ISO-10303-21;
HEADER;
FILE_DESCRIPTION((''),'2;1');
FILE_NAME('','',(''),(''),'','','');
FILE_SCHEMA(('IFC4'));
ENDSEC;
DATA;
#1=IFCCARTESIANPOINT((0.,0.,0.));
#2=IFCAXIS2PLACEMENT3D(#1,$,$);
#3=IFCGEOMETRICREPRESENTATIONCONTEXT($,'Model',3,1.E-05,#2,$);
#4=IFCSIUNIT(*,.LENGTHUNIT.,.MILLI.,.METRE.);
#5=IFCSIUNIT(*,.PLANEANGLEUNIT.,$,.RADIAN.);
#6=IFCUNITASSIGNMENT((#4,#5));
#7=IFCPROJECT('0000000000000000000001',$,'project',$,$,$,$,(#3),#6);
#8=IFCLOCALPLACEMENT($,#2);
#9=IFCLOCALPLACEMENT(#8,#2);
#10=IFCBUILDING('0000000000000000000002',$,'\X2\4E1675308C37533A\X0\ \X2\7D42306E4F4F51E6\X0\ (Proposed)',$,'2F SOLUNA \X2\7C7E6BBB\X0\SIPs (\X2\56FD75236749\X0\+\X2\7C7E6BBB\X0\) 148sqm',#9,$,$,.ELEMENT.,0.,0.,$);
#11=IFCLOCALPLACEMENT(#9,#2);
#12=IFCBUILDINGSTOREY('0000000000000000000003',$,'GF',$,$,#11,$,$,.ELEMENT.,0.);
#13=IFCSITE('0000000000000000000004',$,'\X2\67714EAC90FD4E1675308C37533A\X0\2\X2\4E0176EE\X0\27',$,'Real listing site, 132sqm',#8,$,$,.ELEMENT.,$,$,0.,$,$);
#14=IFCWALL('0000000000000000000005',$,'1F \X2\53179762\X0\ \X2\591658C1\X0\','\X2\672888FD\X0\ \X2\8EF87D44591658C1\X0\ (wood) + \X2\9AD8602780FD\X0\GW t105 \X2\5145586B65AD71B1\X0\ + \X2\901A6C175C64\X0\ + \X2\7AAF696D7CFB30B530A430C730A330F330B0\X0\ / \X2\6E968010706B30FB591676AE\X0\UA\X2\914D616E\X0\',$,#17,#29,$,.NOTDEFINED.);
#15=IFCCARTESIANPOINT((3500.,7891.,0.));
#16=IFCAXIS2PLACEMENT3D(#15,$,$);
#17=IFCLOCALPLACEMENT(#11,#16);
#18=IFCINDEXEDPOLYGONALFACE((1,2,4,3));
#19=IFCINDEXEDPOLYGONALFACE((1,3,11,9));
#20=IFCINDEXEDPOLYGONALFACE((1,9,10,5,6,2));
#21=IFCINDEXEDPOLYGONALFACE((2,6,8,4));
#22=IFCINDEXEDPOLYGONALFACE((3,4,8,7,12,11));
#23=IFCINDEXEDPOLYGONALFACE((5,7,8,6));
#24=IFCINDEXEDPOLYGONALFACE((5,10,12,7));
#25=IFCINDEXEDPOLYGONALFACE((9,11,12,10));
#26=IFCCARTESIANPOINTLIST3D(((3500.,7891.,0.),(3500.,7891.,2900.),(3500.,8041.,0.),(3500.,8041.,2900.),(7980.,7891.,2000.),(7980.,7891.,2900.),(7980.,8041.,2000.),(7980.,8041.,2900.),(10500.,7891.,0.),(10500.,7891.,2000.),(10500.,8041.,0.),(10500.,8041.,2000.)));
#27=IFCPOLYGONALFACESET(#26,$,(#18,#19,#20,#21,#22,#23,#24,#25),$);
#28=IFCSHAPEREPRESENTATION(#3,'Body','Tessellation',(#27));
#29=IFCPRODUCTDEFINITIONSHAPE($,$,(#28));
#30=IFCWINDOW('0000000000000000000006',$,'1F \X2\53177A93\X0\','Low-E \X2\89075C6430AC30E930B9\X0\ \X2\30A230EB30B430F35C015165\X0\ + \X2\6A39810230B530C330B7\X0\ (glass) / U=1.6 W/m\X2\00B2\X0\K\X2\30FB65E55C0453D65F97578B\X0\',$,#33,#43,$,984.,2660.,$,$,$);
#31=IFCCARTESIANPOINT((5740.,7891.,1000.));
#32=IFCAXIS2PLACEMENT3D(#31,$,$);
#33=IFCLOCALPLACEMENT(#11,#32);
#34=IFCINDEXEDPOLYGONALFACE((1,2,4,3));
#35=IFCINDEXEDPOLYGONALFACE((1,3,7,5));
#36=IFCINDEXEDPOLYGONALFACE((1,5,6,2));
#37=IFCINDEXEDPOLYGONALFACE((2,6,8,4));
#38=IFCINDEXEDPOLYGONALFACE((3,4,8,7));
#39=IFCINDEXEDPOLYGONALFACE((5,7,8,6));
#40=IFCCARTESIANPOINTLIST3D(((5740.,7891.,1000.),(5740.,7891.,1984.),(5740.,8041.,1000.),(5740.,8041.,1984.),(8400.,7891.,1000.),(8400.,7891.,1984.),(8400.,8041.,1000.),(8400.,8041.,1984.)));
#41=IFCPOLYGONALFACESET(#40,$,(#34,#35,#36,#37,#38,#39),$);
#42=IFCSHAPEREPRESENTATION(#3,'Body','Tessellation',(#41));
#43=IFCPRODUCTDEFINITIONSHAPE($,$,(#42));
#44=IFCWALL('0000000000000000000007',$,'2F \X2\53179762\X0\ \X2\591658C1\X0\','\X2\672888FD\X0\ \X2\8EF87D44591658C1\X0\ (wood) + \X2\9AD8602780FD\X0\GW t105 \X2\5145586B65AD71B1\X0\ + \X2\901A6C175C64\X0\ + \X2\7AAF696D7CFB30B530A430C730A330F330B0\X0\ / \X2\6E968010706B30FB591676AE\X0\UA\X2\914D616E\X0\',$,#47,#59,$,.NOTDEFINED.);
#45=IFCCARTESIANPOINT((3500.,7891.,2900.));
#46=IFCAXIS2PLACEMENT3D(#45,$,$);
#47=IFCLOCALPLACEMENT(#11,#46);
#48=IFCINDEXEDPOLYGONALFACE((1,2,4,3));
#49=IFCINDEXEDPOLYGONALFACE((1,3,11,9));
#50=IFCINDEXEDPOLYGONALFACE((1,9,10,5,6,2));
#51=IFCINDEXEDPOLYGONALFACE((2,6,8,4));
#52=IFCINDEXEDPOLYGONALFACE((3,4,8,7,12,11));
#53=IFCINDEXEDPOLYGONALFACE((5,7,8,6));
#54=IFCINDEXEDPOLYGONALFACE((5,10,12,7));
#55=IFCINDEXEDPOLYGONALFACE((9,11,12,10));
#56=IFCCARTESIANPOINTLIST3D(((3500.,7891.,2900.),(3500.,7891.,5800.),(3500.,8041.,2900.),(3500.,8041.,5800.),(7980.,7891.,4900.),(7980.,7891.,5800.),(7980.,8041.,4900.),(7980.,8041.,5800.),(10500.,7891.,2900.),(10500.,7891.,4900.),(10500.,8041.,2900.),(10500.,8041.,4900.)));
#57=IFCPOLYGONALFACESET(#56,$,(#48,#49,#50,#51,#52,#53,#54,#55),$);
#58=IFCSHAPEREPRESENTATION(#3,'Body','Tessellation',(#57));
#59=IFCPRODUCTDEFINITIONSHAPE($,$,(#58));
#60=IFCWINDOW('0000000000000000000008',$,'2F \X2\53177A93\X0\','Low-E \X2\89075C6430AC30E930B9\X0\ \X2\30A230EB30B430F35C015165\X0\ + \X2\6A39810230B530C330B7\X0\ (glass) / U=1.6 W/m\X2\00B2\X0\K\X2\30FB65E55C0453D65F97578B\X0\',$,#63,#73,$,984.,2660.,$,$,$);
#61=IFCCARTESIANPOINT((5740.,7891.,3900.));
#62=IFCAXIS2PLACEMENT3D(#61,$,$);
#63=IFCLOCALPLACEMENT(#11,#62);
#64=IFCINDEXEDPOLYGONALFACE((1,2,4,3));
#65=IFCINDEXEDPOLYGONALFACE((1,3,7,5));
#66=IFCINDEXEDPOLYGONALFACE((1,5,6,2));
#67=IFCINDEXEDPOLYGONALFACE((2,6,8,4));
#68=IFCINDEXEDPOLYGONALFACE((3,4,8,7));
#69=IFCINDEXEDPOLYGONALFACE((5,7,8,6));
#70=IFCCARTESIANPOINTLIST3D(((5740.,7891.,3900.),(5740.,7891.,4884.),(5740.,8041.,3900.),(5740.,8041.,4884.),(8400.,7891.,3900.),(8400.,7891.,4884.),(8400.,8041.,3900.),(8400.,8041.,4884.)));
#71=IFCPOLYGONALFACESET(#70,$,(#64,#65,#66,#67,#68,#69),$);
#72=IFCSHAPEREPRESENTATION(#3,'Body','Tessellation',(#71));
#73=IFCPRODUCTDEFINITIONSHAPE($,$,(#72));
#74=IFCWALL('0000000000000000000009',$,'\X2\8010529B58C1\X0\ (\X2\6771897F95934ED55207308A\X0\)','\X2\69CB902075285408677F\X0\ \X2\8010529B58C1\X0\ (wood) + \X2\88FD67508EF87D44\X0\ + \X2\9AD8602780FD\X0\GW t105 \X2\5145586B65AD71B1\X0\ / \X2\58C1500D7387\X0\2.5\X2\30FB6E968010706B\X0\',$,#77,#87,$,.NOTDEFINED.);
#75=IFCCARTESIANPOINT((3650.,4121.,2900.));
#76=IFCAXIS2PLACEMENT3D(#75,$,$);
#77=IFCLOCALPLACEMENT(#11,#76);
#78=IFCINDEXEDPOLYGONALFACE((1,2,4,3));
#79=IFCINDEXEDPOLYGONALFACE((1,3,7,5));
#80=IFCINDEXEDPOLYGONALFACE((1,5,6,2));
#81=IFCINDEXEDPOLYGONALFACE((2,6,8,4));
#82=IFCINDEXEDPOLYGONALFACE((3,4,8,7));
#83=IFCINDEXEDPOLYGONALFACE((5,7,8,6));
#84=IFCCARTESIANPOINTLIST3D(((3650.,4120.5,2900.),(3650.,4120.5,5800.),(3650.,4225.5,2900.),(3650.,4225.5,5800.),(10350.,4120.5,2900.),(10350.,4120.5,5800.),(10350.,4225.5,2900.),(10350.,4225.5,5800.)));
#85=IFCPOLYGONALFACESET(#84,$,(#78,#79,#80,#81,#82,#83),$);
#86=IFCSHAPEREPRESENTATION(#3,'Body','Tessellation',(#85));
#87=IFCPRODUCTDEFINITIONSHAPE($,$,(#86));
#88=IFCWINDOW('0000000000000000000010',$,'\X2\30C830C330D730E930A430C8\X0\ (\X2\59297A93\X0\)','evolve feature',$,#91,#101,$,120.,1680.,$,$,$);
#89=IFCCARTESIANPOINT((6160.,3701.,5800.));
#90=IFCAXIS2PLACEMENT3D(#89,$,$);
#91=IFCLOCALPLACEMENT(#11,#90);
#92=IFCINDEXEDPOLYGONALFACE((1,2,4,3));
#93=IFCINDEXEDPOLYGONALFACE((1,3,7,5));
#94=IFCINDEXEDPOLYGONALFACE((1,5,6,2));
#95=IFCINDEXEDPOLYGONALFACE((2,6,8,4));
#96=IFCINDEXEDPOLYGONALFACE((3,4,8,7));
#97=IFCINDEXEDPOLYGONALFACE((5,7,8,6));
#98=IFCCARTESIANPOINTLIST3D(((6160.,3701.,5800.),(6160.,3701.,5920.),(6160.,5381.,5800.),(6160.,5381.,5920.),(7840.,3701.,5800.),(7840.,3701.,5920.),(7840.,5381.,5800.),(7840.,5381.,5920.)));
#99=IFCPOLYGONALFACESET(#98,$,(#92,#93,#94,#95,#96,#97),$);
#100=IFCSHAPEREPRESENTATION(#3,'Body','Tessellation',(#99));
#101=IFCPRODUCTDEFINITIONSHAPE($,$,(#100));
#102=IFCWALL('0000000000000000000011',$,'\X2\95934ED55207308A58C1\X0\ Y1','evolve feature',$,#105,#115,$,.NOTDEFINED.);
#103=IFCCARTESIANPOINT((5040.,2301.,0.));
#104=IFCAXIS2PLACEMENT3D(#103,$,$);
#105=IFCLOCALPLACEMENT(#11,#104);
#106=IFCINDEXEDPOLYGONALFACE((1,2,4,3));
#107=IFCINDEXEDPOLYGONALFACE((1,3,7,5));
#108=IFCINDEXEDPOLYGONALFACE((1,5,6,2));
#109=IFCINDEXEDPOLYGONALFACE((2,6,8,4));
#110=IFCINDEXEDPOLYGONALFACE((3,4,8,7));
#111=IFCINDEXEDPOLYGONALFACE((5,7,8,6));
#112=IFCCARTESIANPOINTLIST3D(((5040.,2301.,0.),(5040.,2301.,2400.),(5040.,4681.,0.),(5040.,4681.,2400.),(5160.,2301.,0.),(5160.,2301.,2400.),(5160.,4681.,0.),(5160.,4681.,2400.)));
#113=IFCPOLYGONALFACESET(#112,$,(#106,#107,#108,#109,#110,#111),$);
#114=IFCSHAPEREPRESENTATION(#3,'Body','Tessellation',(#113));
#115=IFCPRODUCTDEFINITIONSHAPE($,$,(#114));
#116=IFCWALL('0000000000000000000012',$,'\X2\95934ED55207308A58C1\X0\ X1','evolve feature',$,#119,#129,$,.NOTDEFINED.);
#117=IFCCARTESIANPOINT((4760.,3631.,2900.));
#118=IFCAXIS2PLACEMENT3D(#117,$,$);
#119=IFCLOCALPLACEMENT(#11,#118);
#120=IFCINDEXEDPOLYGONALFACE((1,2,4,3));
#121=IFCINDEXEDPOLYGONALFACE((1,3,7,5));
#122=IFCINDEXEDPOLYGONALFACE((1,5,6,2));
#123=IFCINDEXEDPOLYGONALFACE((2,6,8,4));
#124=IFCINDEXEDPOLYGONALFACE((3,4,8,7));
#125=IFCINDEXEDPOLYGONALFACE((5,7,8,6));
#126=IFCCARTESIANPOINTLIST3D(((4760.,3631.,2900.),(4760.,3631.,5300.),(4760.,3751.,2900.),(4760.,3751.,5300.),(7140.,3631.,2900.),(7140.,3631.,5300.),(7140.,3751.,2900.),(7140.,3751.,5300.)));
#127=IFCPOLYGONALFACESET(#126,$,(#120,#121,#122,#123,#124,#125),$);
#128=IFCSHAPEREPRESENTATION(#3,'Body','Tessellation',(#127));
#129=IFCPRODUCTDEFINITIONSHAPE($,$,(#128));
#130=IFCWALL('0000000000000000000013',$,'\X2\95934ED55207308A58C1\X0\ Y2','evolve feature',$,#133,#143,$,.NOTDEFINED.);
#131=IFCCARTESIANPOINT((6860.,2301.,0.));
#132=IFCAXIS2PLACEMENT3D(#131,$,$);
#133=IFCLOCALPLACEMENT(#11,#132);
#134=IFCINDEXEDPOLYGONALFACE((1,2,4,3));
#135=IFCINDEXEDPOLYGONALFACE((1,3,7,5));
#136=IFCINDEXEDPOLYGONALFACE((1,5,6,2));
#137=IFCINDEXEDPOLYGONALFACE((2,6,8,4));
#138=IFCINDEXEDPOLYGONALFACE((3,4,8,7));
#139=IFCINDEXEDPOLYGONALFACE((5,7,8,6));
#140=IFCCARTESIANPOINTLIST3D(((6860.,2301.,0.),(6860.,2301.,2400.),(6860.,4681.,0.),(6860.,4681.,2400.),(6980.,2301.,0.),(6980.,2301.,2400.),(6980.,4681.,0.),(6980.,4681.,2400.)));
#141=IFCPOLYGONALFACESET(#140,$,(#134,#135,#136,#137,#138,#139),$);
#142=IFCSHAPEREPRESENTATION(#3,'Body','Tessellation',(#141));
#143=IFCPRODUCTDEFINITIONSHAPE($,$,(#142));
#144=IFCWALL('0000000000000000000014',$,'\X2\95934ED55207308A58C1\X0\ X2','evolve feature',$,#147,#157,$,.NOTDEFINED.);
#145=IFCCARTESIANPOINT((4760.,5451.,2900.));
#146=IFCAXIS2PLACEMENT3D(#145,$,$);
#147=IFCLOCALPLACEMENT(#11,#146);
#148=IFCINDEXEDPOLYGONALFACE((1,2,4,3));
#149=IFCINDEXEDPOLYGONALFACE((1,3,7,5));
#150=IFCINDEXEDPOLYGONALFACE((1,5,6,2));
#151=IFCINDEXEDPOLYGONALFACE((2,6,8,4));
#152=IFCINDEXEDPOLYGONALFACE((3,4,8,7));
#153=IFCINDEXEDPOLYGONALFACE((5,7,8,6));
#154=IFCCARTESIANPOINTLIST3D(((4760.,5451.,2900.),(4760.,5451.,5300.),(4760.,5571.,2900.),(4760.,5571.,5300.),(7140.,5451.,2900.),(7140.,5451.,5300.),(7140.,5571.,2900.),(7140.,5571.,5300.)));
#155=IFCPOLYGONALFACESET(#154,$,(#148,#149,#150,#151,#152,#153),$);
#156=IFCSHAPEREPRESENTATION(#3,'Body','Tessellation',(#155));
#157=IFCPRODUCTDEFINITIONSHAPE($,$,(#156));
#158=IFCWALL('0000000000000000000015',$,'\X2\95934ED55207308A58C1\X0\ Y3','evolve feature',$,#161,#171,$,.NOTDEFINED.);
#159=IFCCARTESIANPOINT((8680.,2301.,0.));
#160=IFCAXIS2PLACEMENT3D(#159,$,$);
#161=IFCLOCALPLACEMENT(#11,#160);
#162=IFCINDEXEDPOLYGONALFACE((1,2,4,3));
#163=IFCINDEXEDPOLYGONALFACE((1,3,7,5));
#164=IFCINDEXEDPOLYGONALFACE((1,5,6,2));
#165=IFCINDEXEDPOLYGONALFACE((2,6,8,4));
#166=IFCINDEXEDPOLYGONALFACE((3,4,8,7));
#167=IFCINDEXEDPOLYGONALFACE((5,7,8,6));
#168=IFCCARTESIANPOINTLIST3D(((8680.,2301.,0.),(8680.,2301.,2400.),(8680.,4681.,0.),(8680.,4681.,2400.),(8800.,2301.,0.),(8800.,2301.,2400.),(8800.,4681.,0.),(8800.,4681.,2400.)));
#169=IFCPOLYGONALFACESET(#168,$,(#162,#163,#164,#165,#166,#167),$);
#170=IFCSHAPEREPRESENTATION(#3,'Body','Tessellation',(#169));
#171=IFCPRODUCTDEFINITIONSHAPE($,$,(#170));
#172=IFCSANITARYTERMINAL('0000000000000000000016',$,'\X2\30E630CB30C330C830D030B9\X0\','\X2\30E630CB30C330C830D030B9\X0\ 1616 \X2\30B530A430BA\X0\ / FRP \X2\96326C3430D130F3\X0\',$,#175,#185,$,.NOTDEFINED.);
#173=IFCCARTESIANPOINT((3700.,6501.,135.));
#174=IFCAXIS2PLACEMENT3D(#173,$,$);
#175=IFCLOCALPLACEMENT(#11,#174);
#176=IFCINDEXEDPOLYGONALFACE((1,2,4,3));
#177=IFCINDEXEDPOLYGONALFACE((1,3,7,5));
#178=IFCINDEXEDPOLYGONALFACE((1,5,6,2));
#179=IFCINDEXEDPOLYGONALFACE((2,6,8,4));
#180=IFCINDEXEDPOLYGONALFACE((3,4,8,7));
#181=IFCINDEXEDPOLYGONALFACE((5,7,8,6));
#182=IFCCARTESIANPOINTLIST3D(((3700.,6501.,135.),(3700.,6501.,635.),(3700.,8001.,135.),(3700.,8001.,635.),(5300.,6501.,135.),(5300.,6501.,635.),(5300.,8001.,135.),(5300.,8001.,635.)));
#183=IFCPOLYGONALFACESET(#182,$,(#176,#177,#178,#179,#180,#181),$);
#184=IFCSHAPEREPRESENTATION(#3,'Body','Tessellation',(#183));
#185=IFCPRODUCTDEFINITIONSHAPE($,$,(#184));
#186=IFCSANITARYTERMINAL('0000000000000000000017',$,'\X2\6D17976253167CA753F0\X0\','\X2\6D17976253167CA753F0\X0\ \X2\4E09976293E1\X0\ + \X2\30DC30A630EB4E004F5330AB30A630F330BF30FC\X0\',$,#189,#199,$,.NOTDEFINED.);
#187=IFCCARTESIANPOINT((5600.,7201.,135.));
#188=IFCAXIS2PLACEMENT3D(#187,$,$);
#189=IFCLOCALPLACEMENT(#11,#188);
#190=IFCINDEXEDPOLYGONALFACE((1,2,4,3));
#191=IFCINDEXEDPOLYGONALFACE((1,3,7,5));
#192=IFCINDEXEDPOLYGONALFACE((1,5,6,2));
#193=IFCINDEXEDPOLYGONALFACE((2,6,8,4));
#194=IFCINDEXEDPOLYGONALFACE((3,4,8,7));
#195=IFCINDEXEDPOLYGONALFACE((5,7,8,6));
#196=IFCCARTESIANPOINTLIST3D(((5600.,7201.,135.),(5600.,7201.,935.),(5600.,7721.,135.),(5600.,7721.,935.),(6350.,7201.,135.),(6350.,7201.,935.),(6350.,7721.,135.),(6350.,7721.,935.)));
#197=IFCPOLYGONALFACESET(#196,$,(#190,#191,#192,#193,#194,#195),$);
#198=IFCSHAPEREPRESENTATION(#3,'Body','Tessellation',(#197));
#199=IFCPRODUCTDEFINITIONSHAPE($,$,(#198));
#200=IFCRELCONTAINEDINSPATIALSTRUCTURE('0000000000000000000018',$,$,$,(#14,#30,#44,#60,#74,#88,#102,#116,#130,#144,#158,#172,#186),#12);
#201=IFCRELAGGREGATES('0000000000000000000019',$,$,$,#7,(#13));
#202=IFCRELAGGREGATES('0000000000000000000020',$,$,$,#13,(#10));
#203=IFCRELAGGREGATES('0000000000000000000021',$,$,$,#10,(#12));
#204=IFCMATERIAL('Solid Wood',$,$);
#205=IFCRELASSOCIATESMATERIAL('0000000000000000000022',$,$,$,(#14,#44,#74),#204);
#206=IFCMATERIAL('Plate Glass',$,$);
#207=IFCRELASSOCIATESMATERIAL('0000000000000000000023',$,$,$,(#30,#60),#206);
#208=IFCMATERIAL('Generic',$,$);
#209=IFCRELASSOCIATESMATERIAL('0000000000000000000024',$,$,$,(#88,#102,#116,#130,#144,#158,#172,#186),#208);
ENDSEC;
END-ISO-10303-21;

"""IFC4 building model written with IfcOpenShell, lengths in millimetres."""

from ifc_helpers import new_model, si_unit, frame, frame_2d, origin, place, context, project, spatial, rectangle, extrude, material, element, fill, save


model = new_model("IFC4")

# Units and contexts
model_context = context("Model", 3, precision=1e-05, world=origin())
ifc_project = project(units=[si_unit("LENGTHUNIT", "METRE", prefix="MILLI"), si_unit("PLANEANGLEUNIT", "RADIAN")], contexts=[model_context])

# Site, building, storey
site_placement = place(None, origin())
site = spatial("IfcSite", under=ifc_project, at=site_placement, Name="東京都世田谷区2丁目27", ObjectType="Real listing site, 132sqm", CompositionType="ELEMENT", RefElevation=0.0)
building_placement = place(site_placement, origin())
building = spatial("IfcBuilding", under=site, at=building_placement, Name="世田谷区 終の住処 (Proposed)", ObjectType="2F SOLUNA 籾殻SIPs (国産杉+籾殻) 148sqm", CompositionType="ELEMENT", ElevationOfRefHeight=0.0, ElevationOfTerrain=0.0)
storey_placement = place(building_placement, origin())
storey = spatial("IfcBuildingStorey", under=building, at=storey_placement, Name="GF", CompositionType="ELEMENT", Elevation=0.0)

# Wall, opening, window
ifc_material_1 = material(Name="Solid Wood")
wall_1_placement = place(storey_placement, frame((3500.0, 7891.0, 0.0)))
wall_1 = element("IfcWall", 1, at=wall_1_placement, inside=storey, material=ifc_material_1, Name="1F 北面 外壁", Description="木製 軸組外壁 (wood) + 高性能GW t105 充填断熱 + 通気層 + 窯業系サイディング / 準耐火・外皮UA配慮", PredefinedType="NOTDEFINED", context=model_context, shape_type="SweptSolid", body=[
    extrude(rectangle(XDim=7000.0, YDim=150.0, at=frame_2d((3500.0, 75.0))), frame((3500.0, 7891.0, 0.0)), (0.0, 0.0, 1.0), 2900.0),
])
opening_1_placement = place(storey_placement, frame((5740.0, 7891.0, 1000.0)))
opening_1 = element("IfcOpeningElement", 2, at=opening_1_placement, cuts=wall_1, PredefinedType="NOTDEFINED", context=model_context, shape_type="SweptSolid", body=[
    extrude(rectangle(XDim=2660.0, YDim=150.0, at=frame_2d((1330.0, 75.0))), frame((5740.0, 7891.0, 1000.0)), (0.0, 0.0, 1.0), 984.0),
])
ifc_material_2 = material(Name="Plate Glass")
window_1_placement = place(storey_placement, frame((5740.0, 7891.0, 1000.0)))
window_1 = element("IfcWindow", 3, at=window_1_placement, inside=storey, material=ifc_material_2, Name="1F 北窓", Description="Low-E 複層ガラス アルゴン封入 + 樹脂サッシ (glass) / U=1.6 W/m²K・日射取得型", OverallHeight=984.0, OverallWidth=2660.0, context=model_context, shape_type="SweptSolid", body=[
    extrude(rectangle(XDim=2660.0, YDim=150.0, at=frame_2d((1330.0, 75.0))), frame((5740.0, 7891.0, 1000.0)), (0.0, 0.0, 1.0), 984.0),
])
fill(opening_1, window_1)

# Wall, opening, window
wall_2_placement = place(storey_placement, frame((3500.0, 7891.0, 2900.0)))
wall_2 = element("IfcWall", 4, at=wall_2_placement, inside=storey, material=ifc_material_1, Name="2F 北面 外壁", Description="木製 軸組外壁 (wood) + 高性能GW t105 充填断熱 + 通気層 + 窯業系サイディング / 準耐火・外皮UA配慮", PredefinedType="NOTDEFINED", context=model_context, shape_type="SweptSolid", body=[
    extrude(rectangle(XDim=7000.0, YDim=150.0, at=frame_2d((3500.0, 75.0))), frame((3500.0, 7891.0, 2900.0)), (0.0, 0.0, 1.0), 2900.0),
])
opening_2_placement = place(storey_placement, frame((5740.0, 7891.0, 3900.0)))
opening_2 = element("IfcOpeningElement", 5, at=opening_2_placement, cuts=wall_2, PredefinedType="NOTDEFINED", context=model_context, shape_type="SweptSolid", body=[
    extrude(rectangle(XDim=2660.0, YDim=150.0, at=frame_2d((1330.0, 75.0))), frame((5740.0, 7891.0, 3900.0)), (0.0, 0.0, 1.0), 984.0),
])
window_2_placement = place(storey_placement, frame((5740.0, 7891.0, 3900.0)))
window_2 = element("IfcWindow", 6, at=window_2_placement, inside=storey, material=ifc_material_2, Name="2F 北窓", Description="Low-E 複層ガラス アルゴン封入 + 樹脂サッシ (glass) / U=1.6 W/m²K・日射取得型", OverallHeight=984.0, OverallWidth=2660.0, context=model_context, shape_type="SweptSolid", body=[
    extrude(rectangle(XDim=2660.0, YDim=150.0, at=frame_2d((1330.0, 75.0))), frame((5740.0, 7891.0, 3900.0)), (0.0, 0.0, 1.0), 984.0),
])
fill(opening_2, window_2)

# Wall
wall_3_placement = place(storey_placement, frame((3650.0, 4121.0, 2900.0)))
element("IfcWall", 7, at=wall_3_placement, inside=storey, material=ifc_material_1, Name="耐力壁 (東西間仕切り)", Description="構造用合板 耐力壁 (wood) + 製材軸組 + 高性能GW t105 充填断熱 / 壁倍率2.5・準耐火", PredefinedType="NOTDEFINED", context=model_context, shape_type="SweptSolid", body=[
    extrude(rectangle(XDim=6700.0, YDim=105.0, at=frame_2d((3350.0, 52.0))), frame((3650.0, 4121.0, 2900.0)), (0.0, 0.0, 1.0), 2900.0),
])

# Window
ifc_material_3 = material(Name="Generic")
window_3_placement = place(storey_placement, frame((6160.0, 3701.0, 5800.0)))
element("IfcWindow", 8, at=window_3_placement, inside=storey, material=ifc_material_3, Name="トップライト (天窓)", Description="evolve feature", OverallHeight=120.0, OverallWidth=1680.0, context=model_context, shape_type="SweptSolid", body=[
    extrude(rectangle(XDim=1680.0, YDim=1680.0, at=frame_2d((840.0, 840.0))), frame((6160.0, 3701.0, 5800.0)), (0.0, 0.0, 1.0), 120.0),
])

# Walls
wall_4_placement = place(storey_placement, frame((5040.0, 2301.0, 0.0)))
element("IfcWall", 9, at=wall_4_placement, inside=storey, material=ifc_material_3, Name="間仕切り壁 Y1", Description="evolve feature", PredefinedType="NOTDEFINED", context=model_context, shape_type="SweptSolid", body=[
    extrude(rectangle(XDim=120.0, YDim=2380.0, at=frame_2d((60.0, 1190.0))), frame((5040.0, 2301.0, 0.0)), (0.0, 0.0, 1.0), 2400.0),
])
wall_5_placement = place(storey_placement, frame((4760.0, 3631.0, 2900.0)))
element("IfcWall", 10, at=wall_5_placement, inside=storey, material=ifc_material_3, Name="間仕切り壁 X1", Description="evolve feature", PredefinedType="NOTDEFINED", context=model_context, shape_type="SweptSolid", body=[
    extrude(rectangle(XDim=2380.0, YDim=120.0, at=frame_2d((1190.0, 60.0))), frame((4760.0, 3631.0, 2900.0)), (0.0, 0.0, 1.0), 2400.0),
])
wall_6_placement = place(storey_placement, frame((6860.0, 2301.0, 0.0)))
element("IfcWall", 11, at=wall_6_placement, inside=storey, material=ifc_material_3, Name="間仕切り壁 Y2", Description="evolve feature", PredefinedType="NOTDEFINED", context=model_context, shape_type="SweptSolid", body=[
    extrude(rectangle(XDim=120.0, YDim=2380.0, at=frame_2d((60.0, 1190.0))), frame((6860.0, 2301.0, 0.0)), (0.0, 0.0, 1.0), 2400.0),
])
wall_7_placement = place(storey_placement, frame((4760.0, 5451.0, 2900.0)))
element("IfcWall", 12, at=wall_7_placement, inside=storey, material=ifc_material_3, Name="間仕切り壁 X2", Description="evolve feature", PredefinedType="NOTDEFINED", context=model_context, shape_type="SweptSolid", body=[
    extrude(rectangle(XDim=2380.0, YDim=120.0, at=frame_2d((1190.0, 60.0))), frame((4760.0, 5451.0, 2900.0)), (0.0, 0.0, 1.0), 2400.0),
])
wall_8_placement = place(storey_placement, frame((8680.0, 2301.0, 0.0)))
element("IfcWall", 13, at=wall_8_placement, inside=storey, material=ifc_material_3, Name="間仕切り壁 Y3", Description="evolve feature", PredefinedType="NOTDEFINED", context=model_context, shape_type="SweptSolid", body=[
    extrude(rectangle(XDim=120.0, YDim=2380.0, at=frame_2d((60.0, 1190.0))), frame((8680.0, 2301.0, 0.0)), (0.0, 0.0, 1.0), 2400.0),
])

# Sanitary terminals
sanitary_terminal_1_placement = place(storey_placement, frame((3700.0, 6501.0, 135.0)))
element("IfcSanitaryTerminal", 14, at=sanitary_terminal_1_placement, inside=storey, material=ifc_material_3, Name="ユニットバス", Description="ユニットバス 1616 サイズ / FRP 防水パン", PredefinedType="NOTDEFINED", context=model_context, shape_type="SweptSolid", body=[
    extrude(rectangle(XDim=1600.0, YDim=1500.0, at=frame_2d((800.0, 750.0))), frame((3700.0, 6501.0, 135.0)), (0.0, 0.0, 1.0), 500.0),
])
sanitary_terminal_2_placement = place(storey_placement, frame((5600.0, 7201.0, 135.0)))
element("IfcSanitaryTerminal", 15, at=sanitary_terminal_2_placement, inside=storey, material=ifc_material_3, Name="洗面化粧台", Description="洗面化粧台 三面鏡 + ボウル一体カウンター", PredefinedType="NOTDEFINED", context=model_context, shape_type="SweptSolid", body=[
    extrude(rectangle(XDim=750.0, YDim=520.0, at=frame_2d((375.0, 260.0))), frame((5600.0, 7201.0, 135.0)), (0.0, 0.0, 1.0), 800.0),
])

save(model, "model.ifc")
